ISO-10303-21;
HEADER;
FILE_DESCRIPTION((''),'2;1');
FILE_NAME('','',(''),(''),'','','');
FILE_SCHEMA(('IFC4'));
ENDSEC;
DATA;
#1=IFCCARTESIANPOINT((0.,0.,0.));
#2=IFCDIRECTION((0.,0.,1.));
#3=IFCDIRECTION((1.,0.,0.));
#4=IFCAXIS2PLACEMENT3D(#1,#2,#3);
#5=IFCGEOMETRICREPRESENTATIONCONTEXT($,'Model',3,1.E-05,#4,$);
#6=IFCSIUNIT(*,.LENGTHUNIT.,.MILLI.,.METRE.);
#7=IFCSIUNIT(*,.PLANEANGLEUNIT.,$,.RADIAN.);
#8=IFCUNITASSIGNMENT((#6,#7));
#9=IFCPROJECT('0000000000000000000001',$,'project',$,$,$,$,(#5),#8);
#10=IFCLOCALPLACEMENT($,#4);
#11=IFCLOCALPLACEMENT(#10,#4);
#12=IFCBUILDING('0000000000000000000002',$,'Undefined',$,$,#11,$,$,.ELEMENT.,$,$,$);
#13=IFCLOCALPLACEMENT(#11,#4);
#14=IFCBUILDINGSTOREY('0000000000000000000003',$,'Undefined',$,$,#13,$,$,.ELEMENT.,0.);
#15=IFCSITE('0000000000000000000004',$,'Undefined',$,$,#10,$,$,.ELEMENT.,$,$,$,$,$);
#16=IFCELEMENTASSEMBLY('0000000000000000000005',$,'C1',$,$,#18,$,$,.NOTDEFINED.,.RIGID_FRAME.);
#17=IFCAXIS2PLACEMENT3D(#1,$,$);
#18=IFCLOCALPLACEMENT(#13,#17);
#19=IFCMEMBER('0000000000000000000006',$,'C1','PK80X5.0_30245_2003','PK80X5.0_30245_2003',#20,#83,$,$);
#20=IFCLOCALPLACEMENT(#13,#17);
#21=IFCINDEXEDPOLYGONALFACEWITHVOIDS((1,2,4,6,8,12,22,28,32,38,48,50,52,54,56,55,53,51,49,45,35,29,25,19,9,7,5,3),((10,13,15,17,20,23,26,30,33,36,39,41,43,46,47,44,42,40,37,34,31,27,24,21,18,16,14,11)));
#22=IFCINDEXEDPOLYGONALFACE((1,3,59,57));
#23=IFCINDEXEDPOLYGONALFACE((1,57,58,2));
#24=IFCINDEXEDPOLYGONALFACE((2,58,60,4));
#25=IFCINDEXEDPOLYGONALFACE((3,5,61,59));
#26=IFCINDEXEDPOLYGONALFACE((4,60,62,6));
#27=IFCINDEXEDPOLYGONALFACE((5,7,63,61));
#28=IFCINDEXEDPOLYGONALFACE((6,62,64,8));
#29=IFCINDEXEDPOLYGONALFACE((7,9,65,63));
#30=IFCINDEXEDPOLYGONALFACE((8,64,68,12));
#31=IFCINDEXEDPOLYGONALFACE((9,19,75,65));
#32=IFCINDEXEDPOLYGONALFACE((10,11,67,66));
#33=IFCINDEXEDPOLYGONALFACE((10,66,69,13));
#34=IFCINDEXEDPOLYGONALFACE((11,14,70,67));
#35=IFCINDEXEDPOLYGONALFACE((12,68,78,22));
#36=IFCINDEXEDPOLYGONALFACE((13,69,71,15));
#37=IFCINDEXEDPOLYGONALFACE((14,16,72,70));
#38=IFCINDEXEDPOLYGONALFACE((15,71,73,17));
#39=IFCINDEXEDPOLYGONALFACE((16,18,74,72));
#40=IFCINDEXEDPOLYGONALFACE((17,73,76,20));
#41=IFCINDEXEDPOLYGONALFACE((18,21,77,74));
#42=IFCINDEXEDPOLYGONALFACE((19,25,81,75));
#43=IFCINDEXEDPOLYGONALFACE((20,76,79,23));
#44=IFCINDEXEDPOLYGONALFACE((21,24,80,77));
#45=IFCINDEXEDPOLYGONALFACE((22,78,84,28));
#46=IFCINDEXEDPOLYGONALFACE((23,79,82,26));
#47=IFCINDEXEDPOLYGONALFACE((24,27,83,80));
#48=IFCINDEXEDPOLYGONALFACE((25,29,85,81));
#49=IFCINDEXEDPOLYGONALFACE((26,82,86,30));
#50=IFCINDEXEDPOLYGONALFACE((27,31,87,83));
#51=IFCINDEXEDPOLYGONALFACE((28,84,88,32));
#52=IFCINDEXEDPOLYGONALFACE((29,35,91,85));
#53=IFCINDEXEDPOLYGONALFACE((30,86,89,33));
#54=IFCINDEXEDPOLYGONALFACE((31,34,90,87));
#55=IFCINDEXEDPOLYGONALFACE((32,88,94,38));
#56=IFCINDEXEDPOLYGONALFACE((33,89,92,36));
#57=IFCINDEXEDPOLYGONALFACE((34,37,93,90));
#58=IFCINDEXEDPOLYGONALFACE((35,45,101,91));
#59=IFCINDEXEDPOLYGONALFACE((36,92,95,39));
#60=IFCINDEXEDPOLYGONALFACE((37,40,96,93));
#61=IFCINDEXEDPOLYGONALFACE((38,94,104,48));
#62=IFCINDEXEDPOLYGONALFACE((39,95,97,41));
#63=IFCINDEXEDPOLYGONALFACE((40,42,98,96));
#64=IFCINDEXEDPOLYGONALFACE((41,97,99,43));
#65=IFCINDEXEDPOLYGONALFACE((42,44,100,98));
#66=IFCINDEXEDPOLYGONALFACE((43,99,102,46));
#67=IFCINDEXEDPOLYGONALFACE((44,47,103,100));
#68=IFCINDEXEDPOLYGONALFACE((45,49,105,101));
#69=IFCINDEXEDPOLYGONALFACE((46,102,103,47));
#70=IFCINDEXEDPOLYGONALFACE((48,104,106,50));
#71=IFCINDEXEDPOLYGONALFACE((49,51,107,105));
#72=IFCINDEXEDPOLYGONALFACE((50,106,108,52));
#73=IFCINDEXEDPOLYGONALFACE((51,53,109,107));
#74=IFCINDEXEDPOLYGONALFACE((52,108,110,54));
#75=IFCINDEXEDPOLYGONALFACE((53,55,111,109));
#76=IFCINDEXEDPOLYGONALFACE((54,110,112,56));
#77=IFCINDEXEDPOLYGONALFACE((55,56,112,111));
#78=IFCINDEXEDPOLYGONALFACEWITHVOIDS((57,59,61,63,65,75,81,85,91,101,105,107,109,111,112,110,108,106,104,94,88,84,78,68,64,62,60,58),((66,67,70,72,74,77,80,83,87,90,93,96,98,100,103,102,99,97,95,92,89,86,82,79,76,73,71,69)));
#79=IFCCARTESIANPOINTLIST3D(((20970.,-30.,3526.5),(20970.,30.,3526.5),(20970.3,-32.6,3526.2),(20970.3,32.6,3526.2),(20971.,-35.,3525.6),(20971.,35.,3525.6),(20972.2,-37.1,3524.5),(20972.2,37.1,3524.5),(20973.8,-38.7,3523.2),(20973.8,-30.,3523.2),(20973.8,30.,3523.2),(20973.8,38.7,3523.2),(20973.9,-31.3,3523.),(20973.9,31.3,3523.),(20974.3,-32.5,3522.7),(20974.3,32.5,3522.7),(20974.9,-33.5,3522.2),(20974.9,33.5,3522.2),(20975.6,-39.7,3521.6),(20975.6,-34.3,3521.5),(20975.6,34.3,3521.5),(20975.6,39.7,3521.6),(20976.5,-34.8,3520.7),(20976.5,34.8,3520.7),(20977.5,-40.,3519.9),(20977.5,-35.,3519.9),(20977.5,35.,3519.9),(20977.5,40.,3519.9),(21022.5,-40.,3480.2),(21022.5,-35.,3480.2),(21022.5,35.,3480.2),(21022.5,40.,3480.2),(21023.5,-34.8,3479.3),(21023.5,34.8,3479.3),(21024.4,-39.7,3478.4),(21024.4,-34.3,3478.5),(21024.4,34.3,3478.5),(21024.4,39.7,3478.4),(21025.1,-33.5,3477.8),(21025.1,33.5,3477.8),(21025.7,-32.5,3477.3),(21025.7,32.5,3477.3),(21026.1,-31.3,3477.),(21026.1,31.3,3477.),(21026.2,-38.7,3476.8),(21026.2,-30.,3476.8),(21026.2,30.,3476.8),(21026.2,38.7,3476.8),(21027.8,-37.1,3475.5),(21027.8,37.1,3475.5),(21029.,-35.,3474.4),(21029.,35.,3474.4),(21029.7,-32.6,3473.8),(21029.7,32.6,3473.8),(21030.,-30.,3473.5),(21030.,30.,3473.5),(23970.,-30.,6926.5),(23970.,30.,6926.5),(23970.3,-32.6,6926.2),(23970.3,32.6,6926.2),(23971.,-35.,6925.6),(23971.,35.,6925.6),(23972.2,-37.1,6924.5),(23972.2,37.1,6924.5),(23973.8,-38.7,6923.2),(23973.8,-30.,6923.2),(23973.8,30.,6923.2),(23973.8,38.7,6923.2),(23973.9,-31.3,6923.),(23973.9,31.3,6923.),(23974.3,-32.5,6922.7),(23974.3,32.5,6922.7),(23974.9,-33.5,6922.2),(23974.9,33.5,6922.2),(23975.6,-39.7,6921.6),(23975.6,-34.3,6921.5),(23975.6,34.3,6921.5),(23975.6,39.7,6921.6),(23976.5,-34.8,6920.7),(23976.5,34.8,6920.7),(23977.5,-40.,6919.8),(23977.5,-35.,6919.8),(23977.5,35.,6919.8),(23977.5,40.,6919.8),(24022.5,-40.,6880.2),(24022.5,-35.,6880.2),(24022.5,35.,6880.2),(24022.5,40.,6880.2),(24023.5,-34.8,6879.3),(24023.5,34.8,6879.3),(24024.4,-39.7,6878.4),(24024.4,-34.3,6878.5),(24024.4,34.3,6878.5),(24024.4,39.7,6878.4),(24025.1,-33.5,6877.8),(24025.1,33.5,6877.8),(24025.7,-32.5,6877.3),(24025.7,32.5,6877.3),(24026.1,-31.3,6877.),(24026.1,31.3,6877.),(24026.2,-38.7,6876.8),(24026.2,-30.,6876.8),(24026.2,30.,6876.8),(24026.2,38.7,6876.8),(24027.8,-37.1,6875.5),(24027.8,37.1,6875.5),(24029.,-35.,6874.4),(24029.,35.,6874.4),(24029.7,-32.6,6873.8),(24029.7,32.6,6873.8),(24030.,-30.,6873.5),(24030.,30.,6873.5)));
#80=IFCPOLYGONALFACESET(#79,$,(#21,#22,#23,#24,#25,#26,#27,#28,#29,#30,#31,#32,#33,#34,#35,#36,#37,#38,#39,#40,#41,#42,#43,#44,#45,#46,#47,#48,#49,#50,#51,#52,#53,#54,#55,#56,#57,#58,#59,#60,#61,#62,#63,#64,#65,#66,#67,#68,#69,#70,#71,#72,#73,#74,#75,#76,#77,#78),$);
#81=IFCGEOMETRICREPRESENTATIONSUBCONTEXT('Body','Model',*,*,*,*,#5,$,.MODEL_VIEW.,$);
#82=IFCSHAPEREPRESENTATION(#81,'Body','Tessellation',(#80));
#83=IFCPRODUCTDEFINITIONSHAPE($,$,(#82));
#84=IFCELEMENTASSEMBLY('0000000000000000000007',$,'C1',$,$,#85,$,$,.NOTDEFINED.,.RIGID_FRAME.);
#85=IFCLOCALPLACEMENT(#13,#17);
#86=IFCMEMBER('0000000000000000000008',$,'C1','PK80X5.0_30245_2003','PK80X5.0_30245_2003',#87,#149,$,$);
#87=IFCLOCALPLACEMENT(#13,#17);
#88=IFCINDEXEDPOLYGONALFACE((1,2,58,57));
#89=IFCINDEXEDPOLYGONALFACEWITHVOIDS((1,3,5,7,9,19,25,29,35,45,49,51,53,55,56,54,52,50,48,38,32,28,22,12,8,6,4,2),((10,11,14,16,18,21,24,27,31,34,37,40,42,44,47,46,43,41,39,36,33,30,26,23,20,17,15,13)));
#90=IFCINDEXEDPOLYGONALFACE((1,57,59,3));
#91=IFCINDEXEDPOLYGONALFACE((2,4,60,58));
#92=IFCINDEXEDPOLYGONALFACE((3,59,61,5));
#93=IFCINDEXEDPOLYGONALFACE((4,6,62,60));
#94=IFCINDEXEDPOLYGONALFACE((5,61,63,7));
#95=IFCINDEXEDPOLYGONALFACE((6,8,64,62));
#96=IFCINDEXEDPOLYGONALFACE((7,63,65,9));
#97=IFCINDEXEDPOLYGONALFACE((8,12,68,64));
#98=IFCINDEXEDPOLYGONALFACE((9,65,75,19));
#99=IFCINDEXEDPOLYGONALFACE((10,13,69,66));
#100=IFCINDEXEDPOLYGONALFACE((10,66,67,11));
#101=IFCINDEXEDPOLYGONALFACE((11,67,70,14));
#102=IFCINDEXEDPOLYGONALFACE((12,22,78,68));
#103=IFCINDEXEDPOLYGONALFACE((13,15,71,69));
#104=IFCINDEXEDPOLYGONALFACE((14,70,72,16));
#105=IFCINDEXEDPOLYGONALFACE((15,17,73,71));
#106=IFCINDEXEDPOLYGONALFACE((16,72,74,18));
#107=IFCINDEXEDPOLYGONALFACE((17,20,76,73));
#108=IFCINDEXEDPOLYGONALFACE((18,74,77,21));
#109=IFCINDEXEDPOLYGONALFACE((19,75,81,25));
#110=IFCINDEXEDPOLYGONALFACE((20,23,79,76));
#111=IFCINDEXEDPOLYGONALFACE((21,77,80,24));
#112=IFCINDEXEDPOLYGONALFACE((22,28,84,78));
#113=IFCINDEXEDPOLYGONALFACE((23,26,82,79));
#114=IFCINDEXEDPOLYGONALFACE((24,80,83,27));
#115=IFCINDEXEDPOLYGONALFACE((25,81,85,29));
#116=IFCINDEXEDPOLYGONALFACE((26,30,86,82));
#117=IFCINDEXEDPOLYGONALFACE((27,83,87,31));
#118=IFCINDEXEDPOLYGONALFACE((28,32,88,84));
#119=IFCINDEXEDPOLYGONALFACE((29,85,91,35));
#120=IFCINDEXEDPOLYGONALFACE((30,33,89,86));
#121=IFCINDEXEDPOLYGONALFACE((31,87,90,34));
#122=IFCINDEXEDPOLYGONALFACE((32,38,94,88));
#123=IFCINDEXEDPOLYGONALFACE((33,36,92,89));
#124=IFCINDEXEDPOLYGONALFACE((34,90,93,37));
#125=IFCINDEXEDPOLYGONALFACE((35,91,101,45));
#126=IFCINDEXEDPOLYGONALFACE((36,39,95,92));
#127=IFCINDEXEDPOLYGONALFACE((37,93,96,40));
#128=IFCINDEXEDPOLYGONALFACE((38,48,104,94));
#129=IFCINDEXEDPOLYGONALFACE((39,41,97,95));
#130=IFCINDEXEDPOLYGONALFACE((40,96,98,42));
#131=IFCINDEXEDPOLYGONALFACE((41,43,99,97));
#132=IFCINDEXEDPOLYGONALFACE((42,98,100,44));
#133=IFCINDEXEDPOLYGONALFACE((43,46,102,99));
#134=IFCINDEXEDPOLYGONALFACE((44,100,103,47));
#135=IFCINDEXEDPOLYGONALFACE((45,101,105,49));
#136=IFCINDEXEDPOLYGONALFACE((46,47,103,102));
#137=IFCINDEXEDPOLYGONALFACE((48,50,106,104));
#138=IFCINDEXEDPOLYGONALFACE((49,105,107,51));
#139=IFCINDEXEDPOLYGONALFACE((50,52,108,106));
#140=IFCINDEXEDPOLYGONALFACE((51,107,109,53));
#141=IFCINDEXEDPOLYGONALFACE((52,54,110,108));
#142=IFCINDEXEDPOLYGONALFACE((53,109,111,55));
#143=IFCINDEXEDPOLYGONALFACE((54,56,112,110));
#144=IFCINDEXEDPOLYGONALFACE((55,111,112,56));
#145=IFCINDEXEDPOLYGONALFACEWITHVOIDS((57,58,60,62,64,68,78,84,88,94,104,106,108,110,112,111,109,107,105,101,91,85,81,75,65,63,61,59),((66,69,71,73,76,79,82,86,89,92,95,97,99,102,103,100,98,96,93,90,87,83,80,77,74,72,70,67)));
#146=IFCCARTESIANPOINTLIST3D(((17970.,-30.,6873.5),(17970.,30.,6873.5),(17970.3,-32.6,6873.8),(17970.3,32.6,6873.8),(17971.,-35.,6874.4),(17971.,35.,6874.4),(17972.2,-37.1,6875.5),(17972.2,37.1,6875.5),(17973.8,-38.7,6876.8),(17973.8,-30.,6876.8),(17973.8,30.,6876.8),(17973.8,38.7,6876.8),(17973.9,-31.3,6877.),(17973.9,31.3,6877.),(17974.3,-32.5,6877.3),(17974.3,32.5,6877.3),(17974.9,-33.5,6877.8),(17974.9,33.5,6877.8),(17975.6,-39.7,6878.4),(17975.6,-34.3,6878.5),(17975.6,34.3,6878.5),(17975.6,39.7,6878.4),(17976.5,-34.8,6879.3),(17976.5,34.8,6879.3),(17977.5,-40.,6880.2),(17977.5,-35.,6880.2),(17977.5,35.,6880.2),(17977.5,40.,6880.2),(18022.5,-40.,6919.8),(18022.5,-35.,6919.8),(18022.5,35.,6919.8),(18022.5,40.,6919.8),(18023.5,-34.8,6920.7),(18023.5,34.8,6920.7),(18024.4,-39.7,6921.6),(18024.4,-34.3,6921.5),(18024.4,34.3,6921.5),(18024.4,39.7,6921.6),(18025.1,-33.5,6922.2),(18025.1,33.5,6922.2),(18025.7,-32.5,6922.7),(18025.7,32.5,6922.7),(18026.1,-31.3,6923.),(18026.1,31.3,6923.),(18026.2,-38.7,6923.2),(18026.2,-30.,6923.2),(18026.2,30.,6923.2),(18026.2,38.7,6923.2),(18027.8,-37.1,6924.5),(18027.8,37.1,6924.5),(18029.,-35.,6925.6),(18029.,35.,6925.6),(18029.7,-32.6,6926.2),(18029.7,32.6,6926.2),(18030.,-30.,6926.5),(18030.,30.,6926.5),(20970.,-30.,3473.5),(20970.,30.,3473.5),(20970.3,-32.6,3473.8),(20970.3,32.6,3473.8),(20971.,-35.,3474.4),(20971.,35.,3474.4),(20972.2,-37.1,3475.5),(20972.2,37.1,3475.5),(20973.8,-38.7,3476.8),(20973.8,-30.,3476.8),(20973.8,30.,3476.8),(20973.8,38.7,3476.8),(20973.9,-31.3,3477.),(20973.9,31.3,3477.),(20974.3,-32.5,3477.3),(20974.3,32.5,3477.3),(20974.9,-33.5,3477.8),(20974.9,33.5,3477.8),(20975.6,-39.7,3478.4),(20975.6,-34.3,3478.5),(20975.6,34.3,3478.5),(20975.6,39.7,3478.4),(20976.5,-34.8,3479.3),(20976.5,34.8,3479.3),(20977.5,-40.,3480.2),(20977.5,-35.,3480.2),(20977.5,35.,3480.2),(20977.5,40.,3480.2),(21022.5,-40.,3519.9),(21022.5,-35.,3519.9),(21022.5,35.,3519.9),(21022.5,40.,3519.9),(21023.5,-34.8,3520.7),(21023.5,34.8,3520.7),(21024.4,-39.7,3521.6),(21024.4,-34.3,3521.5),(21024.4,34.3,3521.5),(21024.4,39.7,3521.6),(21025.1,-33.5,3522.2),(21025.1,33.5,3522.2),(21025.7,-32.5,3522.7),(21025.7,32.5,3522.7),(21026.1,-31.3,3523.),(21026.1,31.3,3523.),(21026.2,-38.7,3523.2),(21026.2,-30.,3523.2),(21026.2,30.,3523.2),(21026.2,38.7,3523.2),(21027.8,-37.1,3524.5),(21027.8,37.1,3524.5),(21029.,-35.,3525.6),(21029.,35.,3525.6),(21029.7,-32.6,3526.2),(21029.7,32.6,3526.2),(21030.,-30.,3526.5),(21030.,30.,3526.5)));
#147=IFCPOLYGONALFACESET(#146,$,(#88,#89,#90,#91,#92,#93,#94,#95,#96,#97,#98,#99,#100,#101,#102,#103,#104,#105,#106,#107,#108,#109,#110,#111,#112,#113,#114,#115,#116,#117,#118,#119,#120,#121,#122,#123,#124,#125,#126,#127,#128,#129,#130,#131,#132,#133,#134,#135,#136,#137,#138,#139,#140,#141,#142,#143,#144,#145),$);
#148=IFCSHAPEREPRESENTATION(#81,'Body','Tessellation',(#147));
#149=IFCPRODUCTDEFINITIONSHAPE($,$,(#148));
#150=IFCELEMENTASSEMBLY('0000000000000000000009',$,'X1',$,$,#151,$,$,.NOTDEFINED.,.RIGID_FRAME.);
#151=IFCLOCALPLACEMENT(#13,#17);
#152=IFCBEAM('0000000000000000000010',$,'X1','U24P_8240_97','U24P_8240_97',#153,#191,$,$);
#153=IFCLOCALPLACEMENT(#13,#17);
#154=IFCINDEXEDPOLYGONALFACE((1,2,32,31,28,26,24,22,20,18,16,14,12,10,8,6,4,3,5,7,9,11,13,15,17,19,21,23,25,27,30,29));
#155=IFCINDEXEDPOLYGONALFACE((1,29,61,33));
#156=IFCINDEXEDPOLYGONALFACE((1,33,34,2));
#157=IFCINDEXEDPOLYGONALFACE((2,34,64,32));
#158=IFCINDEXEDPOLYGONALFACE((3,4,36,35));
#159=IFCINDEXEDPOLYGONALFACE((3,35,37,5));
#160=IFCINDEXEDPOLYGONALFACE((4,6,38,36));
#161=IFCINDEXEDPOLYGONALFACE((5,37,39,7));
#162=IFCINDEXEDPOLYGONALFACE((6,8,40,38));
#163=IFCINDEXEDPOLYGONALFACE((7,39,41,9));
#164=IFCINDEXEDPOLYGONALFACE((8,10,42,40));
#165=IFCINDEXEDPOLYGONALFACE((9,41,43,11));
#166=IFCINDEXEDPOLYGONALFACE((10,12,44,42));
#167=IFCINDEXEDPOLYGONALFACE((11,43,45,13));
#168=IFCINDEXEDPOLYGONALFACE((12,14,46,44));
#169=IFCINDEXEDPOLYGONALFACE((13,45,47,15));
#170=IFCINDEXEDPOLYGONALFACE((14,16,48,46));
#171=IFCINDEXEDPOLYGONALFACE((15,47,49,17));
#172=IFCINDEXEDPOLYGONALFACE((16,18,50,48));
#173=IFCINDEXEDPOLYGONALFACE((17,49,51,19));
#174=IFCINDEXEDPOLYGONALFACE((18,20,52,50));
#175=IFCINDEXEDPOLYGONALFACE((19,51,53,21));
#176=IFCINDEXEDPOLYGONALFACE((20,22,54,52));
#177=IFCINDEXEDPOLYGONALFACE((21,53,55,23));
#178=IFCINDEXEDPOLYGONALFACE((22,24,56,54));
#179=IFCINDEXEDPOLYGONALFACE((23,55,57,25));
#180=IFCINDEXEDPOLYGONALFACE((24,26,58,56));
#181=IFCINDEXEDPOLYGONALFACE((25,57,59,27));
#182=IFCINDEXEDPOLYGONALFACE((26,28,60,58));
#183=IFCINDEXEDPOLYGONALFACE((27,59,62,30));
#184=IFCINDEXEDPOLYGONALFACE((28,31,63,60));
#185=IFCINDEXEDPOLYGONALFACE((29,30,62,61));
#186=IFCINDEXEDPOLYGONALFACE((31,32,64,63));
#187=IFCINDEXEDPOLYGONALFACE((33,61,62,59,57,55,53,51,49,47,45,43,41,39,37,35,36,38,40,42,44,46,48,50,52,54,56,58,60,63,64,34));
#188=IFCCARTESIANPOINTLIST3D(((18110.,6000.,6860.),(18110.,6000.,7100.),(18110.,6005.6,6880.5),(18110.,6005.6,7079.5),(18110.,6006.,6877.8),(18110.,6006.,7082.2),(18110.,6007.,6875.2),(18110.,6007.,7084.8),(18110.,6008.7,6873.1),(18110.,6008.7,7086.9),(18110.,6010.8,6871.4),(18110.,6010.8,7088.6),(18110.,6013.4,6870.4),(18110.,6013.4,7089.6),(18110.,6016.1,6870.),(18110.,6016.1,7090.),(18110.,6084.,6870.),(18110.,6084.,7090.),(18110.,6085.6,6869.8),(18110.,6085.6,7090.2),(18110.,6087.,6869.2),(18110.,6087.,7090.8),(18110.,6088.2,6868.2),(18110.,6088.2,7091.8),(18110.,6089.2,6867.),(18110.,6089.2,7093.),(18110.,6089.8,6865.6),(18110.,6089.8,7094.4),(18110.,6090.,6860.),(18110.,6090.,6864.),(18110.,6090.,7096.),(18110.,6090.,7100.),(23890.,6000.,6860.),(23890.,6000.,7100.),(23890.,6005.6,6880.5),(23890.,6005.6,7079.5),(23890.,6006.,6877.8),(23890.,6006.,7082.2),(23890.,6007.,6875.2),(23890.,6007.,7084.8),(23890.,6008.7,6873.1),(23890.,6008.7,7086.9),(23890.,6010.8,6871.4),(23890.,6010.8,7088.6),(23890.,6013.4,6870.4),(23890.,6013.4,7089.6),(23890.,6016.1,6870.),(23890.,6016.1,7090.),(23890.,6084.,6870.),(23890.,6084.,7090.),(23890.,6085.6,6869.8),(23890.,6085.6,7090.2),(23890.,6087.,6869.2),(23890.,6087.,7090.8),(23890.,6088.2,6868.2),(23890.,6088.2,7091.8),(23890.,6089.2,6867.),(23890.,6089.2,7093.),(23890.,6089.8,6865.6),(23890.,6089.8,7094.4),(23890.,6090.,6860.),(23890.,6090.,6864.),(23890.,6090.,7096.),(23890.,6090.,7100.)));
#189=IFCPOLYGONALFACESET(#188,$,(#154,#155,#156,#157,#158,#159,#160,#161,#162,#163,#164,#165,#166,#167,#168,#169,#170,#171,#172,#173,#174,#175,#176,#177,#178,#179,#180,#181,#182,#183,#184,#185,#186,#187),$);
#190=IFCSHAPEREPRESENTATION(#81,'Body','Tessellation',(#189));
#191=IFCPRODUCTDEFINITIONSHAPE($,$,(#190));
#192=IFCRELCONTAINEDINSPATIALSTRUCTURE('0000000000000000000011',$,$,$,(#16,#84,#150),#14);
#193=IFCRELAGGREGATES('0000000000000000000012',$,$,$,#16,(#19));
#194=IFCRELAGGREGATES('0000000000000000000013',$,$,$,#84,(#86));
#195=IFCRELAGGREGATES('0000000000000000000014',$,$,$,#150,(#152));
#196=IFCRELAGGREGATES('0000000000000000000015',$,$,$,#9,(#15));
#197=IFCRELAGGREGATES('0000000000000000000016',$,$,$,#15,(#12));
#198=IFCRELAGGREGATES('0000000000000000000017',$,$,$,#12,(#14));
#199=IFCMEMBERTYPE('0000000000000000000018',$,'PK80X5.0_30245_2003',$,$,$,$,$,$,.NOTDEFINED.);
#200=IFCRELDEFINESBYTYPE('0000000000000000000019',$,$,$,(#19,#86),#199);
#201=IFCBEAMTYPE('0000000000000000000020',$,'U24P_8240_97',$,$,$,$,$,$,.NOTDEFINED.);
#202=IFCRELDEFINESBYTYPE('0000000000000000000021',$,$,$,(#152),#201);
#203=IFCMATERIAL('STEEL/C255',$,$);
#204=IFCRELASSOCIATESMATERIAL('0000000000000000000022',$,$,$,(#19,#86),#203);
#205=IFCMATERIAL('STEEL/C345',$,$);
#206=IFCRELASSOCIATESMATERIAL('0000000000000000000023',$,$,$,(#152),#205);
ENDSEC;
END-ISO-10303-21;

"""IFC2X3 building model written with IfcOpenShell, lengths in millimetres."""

from ifc_helpers import new_model, si_unit, frame, origin_with_axes, origin_2d_with_axis, place, context, subcontext, project, spatial, hollow_rectangle, u_section, extrude, material, type_object, element, aggregate, save


model = new_model("IFC2X3")

# Units and contexts
model_context = context("Model", 3, precision=1e-05, world=origin_with_axes())
body_context = subcontext(model_context, "Body", "Model", "MODEL_VIEW")
ifc_project = project(units=[si_unit("LENGTHUNIT", "METRE", prefix="MILLI"), si_unit("PLANEANGLEUNIT", "RADIAN")], contexts=[model_context])

# Site, building, storey
site_placement = place(None, origin_with_axes())
site = spatial("IfcSite", under=ifc_project, at=site_placement, Name="Undefined", CompositionType="ELEMENT")
building_placement = place(site_placement, origin_with_axes())
building = spatial("IfcBuilding", under=site, at=building_placement, Name="Undefined", CompositionType="ELEMENT")
storey_placement = place(building_placement, origin_with_axes())
storey = spatial("IfcBuildingStorey", under=building, at=storey_placement, Name="Undefined", CompositionType="ELEMENT", Elevation=0.0)

# Shared definitions
ifc_material_1 = material(Name="STEEL/C255")

# Element assemblies, members
assembly_1_placement = place(storey_placement, origin_with_axes())
assembly_1 = element("IfcElementAssembly", 1, at=assembly_1_placement, inside=storey, Name="C1", AssemblyPlace="NOTDEFINED", PredefinedType="RIGID_FRAME")
member_type = type_object("IfcMemberType", Name="PK80X5.0_30245_2003", PredefinedType="NOTDEFINED")
member_1_placement = place(assembly_1_placement, frame((21000.0, 0.0, 3500.0), z_axis=(0.749838, 0.0, -0.661622), x_axis=(0.661622, 0.0, 0.749838)))
member_1 = element("IfcMember", 2, at=member_1_placement, type_object=member_type, material=ifc_material_1, Name="C1", Description="PK80X5.0_30245_2003", ObjectType="PK80X5.0_30245_2003", context=body_context, shape_type="SweptSolid", body=[
    extrude(hollow_rectangle(XDim=80.0, YDim=80.0, WallThickness=5.0, InnerFilletRadius=5.0, OuterFilletRadius=10.0, at=origin_2d_with_axis()), frame((4534.3, 0.0, 0.0), z_axis=(-1.0, 0.0, 0.0), x_axis=(0.0, -1.0, 0.0)), (0.0, 0.0, 1.0), 4534.3),
])
aggregate(assembly_1, [member_1])
assembly_2_placement = place(storey_placement, origin_with_axes())
assembly_2 = element("IfcElementAssembly", 3, at=assembly_2_placement, inside=storey, Name="C1", AssemblyPlace="NOTDEFINED", PredefinedType="RIGID_FRAME")
member_2_placement = place(assembly_2_placement, frame((21000.0, 0.0, 3500.0), z_axis=(-0.749838, 0.0, -0.661622), x_axis=(-0.661622, 0.0, 0.749838)))
member_2 = element("IfcMember", 4, at=member_2_placement, type_object=member_type, material=ifc_material_1, Name="C1", Description="PK80X5.0_30245_2003", ObjectType="PK80X5.0_30245_2003", context=body_context, shape_type="SweptSolid", body=[
    extrude(hollow_rectangle(XDim=80.0, YDim=80.0, WallThickness=5.0, InnerFilletRadius=5.0, OuterFilletRadius=10.0, at=origin_2d_with_axis()), frame((4534.3, 0.0, 0.0), z_axis=(-1.0, 0.0, 0.0), x_axis=(0.0, -1.0, 0.0)), (0.0, 0.0, 1.0), 4534.3),
])
aggregate(assembly_2, [member_2])

# Element assembly, beam
assembly_3_placement = place(storey_placement, origin_with_axes())
assembly_3 = element("IfcElementAssembly", 5, at=assembly_3_placement, inside=storey, Name="X1", AssemblyPlace="NOTDEFINED", PredefinedType="RIGID_FRAME")
ifc_material_2 = material(Name="STEEL/C345")
beam_type_1 = type_object("IfcBeamType", Name="U24P_8240_97", PredefinedType="NOTDEFINED")
beam_1_placement = place(assembly_3_placement, frame((18110.0, 6045.0, 6980.0), z_axis=(0.0, 0.0, -1.0), x_axis=(1.0, 0.0, 0.0)))
beam_1 = element("IfcBeam", 6, at=beam_1_placement, type_object=beam_type_1, material=ifc_material_2, Name="X1", Description="U24P_8240_97", ObjectType="U24P_8240_97", context=body_context, shape_type="SweptSolid", body=[
    extrude(u_section(Depth=240.0, FlangeWidth=90.0, WebThickness=5.6, FlangeThickness=10.0, FilletRadius=10.5, EdgeRadius=6.0, at=origin_2d_with_axis()), frame((5780.0, 0.0, 0.0), z_axis=(-1.0, 0.0, 0.0), x_axis=(0.0, -1.0, 0.0)), (0.0, 0.0, 1.0), 5780.0),
])
aggregate(assembly_3, [beam_1])

save(model, "model.ifc")
